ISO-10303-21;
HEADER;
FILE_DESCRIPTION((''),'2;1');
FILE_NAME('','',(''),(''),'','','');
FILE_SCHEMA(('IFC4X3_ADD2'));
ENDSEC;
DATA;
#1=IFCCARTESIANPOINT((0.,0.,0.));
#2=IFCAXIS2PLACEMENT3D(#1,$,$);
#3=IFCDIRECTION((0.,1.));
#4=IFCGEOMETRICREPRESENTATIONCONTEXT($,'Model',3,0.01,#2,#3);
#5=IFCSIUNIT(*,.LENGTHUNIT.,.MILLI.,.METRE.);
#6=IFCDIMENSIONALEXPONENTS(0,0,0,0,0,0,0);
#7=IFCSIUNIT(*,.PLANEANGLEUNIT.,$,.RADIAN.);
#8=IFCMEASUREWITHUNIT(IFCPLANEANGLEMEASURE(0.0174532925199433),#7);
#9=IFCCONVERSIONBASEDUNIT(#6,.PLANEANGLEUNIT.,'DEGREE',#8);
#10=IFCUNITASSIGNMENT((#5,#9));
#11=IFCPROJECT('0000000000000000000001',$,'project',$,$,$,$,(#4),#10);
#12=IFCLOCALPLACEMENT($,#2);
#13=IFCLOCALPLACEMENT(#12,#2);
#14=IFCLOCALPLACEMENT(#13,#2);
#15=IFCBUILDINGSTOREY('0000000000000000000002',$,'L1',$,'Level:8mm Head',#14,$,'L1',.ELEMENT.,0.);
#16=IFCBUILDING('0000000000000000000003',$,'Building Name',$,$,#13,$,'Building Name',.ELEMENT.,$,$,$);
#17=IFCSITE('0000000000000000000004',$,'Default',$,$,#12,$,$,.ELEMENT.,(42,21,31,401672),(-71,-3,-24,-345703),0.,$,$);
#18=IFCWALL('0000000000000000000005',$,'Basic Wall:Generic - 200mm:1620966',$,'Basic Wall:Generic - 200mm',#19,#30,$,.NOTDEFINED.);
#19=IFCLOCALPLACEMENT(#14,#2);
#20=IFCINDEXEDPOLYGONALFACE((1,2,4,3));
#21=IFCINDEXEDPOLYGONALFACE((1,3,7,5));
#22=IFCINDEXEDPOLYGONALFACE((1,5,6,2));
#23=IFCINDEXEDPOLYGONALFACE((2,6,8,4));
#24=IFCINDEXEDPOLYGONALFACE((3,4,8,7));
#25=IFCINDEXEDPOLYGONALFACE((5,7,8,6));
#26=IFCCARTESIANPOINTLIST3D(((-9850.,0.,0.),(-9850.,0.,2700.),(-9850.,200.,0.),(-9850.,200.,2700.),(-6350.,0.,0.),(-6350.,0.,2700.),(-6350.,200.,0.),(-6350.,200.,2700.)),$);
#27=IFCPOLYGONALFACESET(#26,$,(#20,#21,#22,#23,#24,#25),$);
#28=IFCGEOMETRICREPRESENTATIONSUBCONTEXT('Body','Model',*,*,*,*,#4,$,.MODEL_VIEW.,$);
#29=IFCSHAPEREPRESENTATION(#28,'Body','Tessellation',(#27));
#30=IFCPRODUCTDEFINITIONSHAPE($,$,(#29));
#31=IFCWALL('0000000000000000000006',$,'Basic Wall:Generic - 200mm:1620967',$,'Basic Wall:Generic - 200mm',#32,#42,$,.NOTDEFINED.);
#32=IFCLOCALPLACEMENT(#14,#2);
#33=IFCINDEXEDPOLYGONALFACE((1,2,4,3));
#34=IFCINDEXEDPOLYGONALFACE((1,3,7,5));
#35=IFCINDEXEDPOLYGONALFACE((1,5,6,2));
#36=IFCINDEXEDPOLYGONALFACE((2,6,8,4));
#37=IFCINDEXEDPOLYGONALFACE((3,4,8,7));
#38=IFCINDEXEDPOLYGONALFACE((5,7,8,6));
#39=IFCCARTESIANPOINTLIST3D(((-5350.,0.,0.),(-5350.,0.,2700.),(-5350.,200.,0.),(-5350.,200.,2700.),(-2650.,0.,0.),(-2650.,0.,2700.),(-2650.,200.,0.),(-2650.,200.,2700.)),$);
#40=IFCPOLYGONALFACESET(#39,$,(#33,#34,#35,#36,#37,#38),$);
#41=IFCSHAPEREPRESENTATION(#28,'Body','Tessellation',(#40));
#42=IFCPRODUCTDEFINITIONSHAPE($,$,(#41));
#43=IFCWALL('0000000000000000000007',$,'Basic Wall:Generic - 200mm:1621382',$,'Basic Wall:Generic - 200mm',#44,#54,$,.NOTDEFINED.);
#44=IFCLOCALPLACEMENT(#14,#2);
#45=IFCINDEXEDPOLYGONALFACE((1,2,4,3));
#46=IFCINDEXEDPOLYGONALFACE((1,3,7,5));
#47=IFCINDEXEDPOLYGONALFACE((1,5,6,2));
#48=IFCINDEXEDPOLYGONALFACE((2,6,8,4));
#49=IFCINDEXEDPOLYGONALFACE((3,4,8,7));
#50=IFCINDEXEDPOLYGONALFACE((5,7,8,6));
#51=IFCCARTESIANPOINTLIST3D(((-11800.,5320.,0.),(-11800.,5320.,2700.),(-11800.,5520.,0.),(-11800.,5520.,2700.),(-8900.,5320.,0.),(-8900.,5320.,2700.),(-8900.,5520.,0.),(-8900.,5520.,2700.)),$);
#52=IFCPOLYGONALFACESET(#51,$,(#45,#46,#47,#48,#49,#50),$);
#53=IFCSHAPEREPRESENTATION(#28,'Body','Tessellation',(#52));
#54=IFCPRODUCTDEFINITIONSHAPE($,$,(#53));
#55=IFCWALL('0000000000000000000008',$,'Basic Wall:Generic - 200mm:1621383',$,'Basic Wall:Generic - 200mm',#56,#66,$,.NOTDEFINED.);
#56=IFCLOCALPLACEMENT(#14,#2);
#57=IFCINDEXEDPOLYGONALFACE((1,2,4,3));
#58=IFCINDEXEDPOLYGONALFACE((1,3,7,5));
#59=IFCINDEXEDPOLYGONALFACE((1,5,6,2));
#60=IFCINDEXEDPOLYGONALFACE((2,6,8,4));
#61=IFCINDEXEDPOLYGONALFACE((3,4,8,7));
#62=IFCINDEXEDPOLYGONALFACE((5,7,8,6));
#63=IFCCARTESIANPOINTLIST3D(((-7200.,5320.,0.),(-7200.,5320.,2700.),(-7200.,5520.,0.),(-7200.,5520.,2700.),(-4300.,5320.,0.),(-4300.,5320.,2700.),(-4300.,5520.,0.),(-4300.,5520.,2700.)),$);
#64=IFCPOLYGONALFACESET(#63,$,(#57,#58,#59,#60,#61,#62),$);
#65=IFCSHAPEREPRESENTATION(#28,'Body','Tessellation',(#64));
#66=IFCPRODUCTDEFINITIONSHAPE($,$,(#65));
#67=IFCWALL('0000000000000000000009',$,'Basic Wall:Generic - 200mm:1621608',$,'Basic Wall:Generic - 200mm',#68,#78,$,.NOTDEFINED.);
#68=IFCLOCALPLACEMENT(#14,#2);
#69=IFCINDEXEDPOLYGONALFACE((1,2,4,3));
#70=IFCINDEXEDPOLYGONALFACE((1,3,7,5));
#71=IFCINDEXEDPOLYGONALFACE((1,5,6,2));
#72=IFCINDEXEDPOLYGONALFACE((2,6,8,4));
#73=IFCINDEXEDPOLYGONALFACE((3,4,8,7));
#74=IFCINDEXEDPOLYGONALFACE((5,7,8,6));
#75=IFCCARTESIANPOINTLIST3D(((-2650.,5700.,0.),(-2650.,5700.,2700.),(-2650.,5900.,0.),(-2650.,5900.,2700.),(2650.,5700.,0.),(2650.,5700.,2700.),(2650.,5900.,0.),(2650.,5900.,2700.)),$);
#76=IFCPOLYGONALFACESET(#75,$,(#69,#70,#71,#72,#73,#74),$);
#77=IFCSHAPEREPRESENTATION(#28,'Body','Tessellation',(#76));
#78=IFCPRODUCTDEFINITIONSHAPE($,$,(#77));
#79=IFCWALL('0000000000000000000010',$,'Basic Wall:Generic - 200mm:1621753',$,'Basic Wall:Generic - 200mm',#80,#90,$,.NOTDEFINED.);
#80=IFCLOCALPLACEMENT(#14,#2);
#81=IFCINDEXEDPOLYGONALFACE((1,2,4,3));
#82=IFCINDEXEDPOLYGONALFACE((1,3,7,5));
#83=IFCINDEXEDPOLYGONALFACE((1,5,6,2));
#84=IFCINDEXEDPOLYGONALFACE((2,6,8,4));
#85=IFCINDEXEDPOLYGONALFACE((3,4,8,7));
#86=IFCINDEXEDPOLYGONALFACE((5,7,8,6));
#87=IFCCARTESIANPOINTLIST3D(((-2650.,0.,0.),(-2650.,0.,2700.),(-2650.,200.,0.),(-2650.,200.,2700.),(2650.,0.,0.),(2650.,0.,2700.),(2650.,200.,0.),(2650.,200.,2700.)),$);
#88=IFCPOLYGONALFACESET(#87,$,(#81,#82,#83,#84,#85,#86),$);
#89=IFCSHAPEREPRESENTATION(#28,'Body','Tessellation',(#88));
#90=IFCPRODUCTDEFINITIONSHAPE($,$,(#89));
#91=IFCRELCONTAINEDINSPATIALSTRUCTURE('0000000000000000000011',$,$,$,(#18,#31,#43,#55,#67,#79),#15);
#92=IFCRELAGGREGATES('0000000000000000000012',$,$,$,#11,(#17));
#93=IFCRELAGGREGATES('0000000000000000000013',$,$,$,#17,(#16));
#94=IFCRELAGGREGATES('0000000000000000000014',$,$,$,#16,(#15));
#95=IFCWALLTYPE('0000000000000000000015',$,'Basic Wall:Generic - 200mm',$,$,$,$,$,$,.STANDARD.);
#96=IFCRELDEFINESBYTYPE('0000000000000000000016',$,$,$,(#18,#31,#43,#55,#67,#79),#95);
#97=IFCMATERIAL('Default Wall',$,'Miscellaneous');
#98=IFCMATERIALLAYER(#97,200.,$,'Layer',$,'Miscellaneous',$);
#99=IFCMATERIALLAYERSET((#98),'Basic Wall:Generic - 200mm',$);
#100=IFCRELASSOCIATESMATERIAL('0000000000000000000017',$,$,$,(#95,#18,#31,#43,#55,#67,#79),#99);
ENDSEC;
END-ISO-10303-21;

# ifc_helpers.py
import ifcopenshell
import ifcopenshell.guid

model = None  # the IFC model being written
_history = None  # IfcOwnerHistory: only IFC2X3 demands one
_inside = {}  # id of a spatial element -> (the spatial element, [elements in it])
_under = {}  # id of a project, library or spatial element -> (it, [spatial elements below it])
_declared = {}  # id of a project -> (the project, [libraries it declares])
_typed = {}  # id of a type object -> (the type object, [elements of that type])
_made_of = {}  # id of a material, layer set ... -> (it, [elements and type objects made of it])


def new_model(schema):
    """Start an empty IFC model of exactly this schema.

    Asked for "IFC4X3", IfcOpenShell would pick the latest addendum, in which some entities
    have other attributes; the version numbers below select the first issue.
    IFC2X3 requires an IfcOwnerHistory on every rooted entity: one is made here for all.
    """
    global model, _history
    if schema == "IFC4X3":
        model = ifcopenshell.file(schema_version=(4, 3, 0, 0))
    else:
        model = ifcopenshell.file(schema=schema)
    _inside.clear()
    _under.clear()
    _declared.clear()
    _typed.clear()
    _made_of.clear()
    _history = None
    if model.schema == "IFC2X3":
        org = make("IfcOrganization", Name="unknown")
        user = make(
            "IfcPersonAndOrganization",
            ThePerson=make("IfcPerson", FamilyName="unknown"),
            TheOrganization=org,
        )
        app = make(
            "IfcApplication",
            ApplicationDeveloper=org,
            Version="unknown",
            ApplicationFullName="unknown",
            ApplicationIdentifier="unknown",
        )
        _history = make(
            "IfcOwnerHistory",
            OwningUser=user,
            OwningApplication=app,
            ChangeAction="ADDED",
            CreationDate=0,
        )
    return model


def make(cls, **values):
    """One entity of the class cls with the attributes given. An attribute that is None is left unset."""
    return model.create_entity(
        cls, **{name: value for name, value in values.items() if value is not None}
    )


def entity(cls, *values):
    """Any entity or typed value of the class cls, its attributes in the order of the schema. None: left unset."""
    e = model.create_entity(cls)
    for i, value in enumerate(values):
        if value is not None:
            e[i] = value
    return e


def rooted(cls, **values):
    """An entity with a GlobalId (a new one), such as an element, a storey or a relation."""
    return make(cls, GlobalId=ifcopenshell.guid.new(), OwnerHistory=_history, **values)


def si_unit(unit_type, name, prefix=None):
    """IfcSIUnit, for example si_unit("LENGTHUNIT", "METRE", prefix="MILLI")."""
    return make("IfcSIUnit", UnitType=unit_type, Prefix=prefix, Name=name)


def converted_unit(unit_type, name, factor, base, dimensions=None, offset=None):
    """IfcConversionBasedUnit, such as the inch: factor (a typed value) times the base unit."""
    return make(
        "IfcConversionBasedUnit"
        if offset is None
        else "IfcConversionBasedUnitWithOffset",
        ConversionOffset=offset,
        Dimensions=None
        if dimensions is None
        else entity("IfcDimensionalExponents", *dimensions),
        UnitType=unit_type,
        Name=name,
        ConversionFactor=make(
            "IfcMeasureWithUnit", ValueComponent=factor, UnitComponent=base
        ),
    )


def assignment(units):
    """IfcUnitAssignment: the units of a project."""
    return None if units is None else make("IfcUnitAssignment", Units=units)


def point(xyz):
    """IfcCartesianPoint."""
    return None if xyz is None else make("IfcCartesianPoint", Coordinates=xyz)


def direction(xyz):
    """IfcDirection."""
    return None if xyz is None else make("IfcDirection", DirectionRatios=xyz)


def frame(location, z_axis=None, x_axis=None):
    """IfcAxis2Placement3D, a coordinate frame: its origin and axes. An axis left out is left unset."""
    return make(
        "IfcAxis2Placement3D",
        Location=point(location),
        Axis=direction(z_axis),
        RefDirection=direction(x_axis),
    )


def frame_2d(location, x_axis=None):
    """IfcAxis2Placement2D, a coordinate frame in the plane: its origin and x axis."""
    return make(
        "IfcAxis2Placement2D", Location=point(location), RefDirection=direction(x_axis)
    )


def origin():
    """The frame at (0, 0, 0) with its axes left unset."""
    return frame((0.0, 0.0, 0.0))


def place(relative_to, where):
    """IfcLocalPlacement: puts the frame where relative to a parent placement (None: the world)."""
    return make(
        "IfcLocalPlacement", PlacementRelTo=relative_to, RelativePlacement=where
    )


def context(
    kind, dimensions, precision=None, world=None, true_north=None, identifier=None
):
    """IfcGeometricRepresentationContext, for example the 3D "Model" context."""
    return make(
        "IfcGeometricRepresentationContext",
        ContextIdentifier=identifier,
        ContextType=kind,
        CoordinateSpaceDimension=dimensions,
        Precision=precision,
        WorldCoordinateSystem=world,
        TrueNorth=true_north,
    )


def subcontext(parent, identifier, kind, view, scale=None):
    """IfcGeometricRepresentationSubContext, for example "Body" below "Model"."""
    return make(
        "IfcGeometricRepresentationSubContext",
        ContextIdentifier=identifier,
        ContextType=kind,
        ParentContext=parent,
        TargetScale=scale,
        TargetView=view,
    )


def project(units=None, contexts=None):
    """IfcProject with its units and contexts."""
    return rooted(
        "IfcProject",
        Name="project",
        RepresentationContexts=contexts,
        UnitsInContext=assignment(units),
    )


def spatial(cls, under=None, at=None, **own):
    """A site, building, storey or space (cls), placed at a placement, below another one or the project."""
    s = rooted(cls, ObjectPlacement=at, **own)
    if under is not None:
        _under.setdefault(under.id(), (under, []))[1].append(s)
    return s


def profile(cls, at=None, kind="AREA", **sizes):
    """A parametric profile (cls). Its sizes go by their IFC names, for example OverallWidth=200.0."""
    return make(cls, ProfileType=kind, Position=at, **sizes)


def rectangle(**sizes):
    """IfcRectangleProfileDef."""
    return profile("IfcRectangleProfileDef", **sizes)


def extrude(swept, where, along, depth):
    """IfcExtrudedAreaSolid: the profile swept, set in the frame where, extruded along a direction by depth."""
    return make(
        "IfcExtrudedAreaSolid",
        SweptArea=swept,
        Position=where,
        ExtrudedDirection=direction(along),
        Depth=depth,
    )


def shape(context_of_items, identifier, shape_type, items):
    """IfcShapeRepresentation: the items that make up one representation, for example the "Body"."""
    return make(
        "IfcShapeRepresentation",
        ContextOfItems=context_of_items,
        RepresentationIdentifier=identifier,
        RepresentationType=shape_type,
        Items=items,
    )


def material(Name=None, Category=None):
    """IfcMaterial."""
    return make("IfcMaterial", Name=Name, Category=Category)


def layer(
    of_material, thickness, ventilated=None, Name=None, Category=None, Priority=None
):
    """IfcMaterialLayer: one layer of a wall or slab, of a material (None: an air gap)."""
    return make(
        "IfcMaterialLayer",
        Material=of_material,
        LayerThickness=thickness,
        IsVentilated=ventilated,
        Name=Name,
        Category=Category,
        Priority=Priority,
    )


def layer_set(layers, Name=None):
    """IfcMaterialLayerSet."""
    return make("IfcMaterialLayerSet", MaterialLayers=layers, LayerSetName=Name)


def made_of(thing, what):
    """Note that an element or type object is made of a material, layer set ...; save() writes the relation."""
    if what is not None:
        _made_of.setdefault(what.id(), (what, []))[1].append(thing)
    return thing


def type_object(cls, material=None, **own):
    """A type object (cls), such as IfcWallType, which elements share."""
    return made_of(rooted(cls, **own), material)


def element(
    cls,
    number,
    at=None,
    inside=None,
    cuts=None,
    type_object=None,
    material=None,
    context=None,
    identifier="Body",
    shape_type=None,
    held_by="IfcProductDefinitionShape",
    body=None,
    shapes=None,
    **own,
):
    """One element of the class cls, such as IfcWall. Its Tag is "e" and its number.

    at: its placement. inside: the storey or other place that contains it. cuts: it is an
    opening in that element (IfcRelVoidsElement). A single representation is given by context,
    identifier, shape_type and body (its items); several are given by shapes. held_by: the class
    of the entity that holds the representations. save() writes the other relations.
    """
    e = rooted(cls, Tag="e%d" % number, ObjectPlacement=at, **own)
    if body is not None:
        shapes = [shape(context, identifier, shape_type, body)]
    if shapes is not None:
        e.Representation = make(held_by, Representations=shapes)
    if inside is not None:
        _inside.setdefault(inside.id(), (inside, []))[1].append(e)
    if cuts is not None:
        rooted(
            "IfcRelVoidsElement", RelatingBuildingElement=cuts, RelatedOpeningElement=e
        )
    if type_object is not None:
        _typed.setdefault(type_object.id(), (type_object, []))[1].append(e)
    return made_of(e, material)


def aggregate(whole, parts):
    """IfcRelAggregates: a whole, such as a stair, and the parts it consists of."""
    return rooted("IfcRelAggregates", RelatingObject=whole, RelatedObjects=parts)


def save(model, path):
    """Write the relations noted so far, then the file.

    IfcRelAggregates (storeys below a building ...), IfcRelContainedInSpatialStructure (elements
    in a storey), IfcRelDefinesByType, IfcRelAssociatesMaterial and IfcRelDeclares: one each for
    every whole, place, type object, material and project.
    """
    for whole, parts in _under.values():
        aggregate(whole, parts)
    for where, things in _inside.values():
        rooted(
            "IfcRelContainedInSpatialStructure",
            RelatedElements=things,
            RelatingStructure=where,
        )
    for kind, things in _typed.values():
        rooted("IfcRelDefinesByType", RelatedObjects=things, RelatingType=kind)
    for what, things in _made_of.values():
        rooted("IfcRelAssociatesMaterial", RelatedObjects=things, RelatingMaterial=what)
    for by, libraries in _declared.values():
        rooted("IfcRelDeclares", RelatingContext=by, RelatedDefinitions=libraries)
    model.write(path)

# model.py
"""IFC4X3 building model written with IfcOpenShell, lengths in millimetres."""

from ifc_helpers import new_model, entity, si_unit, converted_unit, direction, frame, frame_2d, origin, place, context, subcontext, project, spatial, rectangle, extrude, material, layer, layer_set, type_object, element, save


model = new_model("IFC4X3")

# Units and contexts
model_context = context("Model", 3, precision=0.01, world=origin(), true_north=direction((0.0, 1.0)))
body_context = subcontext(model_context, "Body", "Model", "MODEL_VIEW")
ifc_project = project(units=[si_unit("LENGTHUNIT", "METRE", prefix="MILLI"), converted_unit("PLANEANGLEUNIT", "DEGREE", entity("IfcPlaneAngleMeasure", 0.0174532925199433), si_unit("PLANEANGLEUNIT", "RADIAN"), dimensions=[0, 0, 0, 0, 0, 0, 0])], contexts=[model_context])

# Site, building, storey
site_placement = place(None, origin())
site = spatial("IfcSite", under=ifc_project, at=site_placement, Name="Default", CompositionType="ELEMENT", RefLatitude=(42, 21, 31, 401672), RefLongitude=(-71, -3, -24, -345703), RefElevation=0.0)
building_placement = place(site_placement, origin())
building = spatial("IfcBuilding", under=site, at=building_placement, Name="Building Name", LongName="Building Name", CompositionType="ELEMENT")
storey_placement = place(building_placement, origin())
storey = spatial("IfcBuildingStorey", under=building, at=storey_placement, Name="L1", ObjectType="Level:8mm Head", LongName="L1", CompositionType="ELEMENT", Elevation=0.0)

# Shared definitions
ifc_material_1 = material(Name="Default Wall", Category="Miscellaneous")
ifc_layer_1 = layer(ifc_material_1, 200.0, Name="Layer", Category="Miscellaneous")
ifc_layer_set_1 = layer_set([ifc_layer_1], Name="Basic Wall:Generic - 200mm")
wall_type = type_object("IfcWallType", Name="Basic Wall:Generic - 200mm", PredefinedType="STANDARD", material=ifc_layer_set_1)

# Walls
wall_1_placement = place(storey_placement, frame((-9850.0, 100.0, 0.0)))
element("IfcWall", 1, at=wall_1_placement, inside=storey, type_object=wall_type, material=ifc_layer_set_1, Name="Basic Wall:Generic - 200mm:1620966", ObjectType="Basic Wall:Generic - 200mm", PredefinedType="NOTDEFINED", context=body_context, shape_type="SweptSolid", body=[
    extrude(rectangle(XDim=3500.0, YDim=200.0, at=frame_2d((1750.0, 0.0), x_axis=(-1.0, 0.0))), origin(), (0.0, 0.0, 1.0), 2700.0),
])
wall_2_placement = place(storey_placement, frame((-5350.0, 100.0, 0.0)))
element("IfcWall", 2, at=wall_2_placement, inside=storey, type_object=wall_type, material=ifc_layer_set_1, Name="Basic Wall:Generic - 200mm:1620967", ObjectType="Basic Wall:Generic - 200mm", PredefinedType="NOTDEFINED", context=body_context, shape_type="SweptSolid", body=[
    extrude(rectangle(XDim=2700.0, YDim=200.0, at=frame_2d((1350.0, 0.0), x_axis=(-1.0, 0.0))), origin(), (0.0, 0.0, 1.0), 2700.0),
])
for number, where, z_axis, x_axis, name in (
    (3, (-8900.0, 5420.0, 0.0), (0.0, 0.0, 1.0), (-1.0, 0.0, 0.0), "Basic Wall:Generic - 200mm:1621382"),
    (4, (-4300.0, 5420.0, 0.0), (0.0, 0.0, 1.0), (-1.0, 0.0, 0.0), "Basic Wall:Generic - 200mm:1621383"),
):
    element("IfcWall", number, at=place(storey_placement, frame(where, z_axis=z_axis, x_axis=x_axis)), inside=storey, type_object=wall_type, material=ifc_layer_set_1, Name=name, ObjectType="Basic Wall:Generic - 200mm", PredefinedType="NOTDEFINED", context=body_context, shape_type="SweptSolid", body=[
        extrude(rectangle(XDim=2900.0, YDim=200.0, at=frame_2d((1450.0, 0.0), x_axis=(-1.0, 0.0))), origin(), (0.0, 0.0, 1.0), 2700.0),
    ])
wall_3_placement = place(storey_placement, frame((-2650.0, 5800.0, 0.0)))
element("IfcWall", 5, at=wall_3_placement, inside=storey, type_object=wall_type, material=ifc_layer_set_1, Name="Basic Wall:Generic - 200mm:1621608", ObjectType="Basic Wall:Generic - 200mm", PredefinedType="NOTDEFINED", context=body_context, shape_type="SweptSolid", body=[
    extrude(rectangle(XDim=5300.0, YDim=200.0, at=frame_2d((2650.0, 0.0), x_axis=(-1.0, 0.0))), origin(), (0.0, 0.0, 1.0), 2700.0),
])
wall_4_placement = place(storey_placement, frame((2650.0, 100.0, 0.0), z_axis=(0.0, 0.0, 1.0), x_axis=(-1.0, 0.0, 0.0)))
element("IfcWall", 6, at=wall_4_placement, inside=storey, type_object=wall_type, material=ifc_layer_set_1, Name="Basic Wall:Generic - 200mm:1621753", ObjectType="Basic Wall:Generic - 200mm", PredefinedType="NOTDEFINED", context=body_context, shape_type="SweptSolid", body=[
    extrude(rectangle(XDim=5300.0, YDim=200.0, at=frame_2d((2650.0, 0.0), x_axis=(-1.0, 0.0))), origin(), (0.0, 0.0, 1.0), 2700.0),
])

save(model, "model.ifc")
